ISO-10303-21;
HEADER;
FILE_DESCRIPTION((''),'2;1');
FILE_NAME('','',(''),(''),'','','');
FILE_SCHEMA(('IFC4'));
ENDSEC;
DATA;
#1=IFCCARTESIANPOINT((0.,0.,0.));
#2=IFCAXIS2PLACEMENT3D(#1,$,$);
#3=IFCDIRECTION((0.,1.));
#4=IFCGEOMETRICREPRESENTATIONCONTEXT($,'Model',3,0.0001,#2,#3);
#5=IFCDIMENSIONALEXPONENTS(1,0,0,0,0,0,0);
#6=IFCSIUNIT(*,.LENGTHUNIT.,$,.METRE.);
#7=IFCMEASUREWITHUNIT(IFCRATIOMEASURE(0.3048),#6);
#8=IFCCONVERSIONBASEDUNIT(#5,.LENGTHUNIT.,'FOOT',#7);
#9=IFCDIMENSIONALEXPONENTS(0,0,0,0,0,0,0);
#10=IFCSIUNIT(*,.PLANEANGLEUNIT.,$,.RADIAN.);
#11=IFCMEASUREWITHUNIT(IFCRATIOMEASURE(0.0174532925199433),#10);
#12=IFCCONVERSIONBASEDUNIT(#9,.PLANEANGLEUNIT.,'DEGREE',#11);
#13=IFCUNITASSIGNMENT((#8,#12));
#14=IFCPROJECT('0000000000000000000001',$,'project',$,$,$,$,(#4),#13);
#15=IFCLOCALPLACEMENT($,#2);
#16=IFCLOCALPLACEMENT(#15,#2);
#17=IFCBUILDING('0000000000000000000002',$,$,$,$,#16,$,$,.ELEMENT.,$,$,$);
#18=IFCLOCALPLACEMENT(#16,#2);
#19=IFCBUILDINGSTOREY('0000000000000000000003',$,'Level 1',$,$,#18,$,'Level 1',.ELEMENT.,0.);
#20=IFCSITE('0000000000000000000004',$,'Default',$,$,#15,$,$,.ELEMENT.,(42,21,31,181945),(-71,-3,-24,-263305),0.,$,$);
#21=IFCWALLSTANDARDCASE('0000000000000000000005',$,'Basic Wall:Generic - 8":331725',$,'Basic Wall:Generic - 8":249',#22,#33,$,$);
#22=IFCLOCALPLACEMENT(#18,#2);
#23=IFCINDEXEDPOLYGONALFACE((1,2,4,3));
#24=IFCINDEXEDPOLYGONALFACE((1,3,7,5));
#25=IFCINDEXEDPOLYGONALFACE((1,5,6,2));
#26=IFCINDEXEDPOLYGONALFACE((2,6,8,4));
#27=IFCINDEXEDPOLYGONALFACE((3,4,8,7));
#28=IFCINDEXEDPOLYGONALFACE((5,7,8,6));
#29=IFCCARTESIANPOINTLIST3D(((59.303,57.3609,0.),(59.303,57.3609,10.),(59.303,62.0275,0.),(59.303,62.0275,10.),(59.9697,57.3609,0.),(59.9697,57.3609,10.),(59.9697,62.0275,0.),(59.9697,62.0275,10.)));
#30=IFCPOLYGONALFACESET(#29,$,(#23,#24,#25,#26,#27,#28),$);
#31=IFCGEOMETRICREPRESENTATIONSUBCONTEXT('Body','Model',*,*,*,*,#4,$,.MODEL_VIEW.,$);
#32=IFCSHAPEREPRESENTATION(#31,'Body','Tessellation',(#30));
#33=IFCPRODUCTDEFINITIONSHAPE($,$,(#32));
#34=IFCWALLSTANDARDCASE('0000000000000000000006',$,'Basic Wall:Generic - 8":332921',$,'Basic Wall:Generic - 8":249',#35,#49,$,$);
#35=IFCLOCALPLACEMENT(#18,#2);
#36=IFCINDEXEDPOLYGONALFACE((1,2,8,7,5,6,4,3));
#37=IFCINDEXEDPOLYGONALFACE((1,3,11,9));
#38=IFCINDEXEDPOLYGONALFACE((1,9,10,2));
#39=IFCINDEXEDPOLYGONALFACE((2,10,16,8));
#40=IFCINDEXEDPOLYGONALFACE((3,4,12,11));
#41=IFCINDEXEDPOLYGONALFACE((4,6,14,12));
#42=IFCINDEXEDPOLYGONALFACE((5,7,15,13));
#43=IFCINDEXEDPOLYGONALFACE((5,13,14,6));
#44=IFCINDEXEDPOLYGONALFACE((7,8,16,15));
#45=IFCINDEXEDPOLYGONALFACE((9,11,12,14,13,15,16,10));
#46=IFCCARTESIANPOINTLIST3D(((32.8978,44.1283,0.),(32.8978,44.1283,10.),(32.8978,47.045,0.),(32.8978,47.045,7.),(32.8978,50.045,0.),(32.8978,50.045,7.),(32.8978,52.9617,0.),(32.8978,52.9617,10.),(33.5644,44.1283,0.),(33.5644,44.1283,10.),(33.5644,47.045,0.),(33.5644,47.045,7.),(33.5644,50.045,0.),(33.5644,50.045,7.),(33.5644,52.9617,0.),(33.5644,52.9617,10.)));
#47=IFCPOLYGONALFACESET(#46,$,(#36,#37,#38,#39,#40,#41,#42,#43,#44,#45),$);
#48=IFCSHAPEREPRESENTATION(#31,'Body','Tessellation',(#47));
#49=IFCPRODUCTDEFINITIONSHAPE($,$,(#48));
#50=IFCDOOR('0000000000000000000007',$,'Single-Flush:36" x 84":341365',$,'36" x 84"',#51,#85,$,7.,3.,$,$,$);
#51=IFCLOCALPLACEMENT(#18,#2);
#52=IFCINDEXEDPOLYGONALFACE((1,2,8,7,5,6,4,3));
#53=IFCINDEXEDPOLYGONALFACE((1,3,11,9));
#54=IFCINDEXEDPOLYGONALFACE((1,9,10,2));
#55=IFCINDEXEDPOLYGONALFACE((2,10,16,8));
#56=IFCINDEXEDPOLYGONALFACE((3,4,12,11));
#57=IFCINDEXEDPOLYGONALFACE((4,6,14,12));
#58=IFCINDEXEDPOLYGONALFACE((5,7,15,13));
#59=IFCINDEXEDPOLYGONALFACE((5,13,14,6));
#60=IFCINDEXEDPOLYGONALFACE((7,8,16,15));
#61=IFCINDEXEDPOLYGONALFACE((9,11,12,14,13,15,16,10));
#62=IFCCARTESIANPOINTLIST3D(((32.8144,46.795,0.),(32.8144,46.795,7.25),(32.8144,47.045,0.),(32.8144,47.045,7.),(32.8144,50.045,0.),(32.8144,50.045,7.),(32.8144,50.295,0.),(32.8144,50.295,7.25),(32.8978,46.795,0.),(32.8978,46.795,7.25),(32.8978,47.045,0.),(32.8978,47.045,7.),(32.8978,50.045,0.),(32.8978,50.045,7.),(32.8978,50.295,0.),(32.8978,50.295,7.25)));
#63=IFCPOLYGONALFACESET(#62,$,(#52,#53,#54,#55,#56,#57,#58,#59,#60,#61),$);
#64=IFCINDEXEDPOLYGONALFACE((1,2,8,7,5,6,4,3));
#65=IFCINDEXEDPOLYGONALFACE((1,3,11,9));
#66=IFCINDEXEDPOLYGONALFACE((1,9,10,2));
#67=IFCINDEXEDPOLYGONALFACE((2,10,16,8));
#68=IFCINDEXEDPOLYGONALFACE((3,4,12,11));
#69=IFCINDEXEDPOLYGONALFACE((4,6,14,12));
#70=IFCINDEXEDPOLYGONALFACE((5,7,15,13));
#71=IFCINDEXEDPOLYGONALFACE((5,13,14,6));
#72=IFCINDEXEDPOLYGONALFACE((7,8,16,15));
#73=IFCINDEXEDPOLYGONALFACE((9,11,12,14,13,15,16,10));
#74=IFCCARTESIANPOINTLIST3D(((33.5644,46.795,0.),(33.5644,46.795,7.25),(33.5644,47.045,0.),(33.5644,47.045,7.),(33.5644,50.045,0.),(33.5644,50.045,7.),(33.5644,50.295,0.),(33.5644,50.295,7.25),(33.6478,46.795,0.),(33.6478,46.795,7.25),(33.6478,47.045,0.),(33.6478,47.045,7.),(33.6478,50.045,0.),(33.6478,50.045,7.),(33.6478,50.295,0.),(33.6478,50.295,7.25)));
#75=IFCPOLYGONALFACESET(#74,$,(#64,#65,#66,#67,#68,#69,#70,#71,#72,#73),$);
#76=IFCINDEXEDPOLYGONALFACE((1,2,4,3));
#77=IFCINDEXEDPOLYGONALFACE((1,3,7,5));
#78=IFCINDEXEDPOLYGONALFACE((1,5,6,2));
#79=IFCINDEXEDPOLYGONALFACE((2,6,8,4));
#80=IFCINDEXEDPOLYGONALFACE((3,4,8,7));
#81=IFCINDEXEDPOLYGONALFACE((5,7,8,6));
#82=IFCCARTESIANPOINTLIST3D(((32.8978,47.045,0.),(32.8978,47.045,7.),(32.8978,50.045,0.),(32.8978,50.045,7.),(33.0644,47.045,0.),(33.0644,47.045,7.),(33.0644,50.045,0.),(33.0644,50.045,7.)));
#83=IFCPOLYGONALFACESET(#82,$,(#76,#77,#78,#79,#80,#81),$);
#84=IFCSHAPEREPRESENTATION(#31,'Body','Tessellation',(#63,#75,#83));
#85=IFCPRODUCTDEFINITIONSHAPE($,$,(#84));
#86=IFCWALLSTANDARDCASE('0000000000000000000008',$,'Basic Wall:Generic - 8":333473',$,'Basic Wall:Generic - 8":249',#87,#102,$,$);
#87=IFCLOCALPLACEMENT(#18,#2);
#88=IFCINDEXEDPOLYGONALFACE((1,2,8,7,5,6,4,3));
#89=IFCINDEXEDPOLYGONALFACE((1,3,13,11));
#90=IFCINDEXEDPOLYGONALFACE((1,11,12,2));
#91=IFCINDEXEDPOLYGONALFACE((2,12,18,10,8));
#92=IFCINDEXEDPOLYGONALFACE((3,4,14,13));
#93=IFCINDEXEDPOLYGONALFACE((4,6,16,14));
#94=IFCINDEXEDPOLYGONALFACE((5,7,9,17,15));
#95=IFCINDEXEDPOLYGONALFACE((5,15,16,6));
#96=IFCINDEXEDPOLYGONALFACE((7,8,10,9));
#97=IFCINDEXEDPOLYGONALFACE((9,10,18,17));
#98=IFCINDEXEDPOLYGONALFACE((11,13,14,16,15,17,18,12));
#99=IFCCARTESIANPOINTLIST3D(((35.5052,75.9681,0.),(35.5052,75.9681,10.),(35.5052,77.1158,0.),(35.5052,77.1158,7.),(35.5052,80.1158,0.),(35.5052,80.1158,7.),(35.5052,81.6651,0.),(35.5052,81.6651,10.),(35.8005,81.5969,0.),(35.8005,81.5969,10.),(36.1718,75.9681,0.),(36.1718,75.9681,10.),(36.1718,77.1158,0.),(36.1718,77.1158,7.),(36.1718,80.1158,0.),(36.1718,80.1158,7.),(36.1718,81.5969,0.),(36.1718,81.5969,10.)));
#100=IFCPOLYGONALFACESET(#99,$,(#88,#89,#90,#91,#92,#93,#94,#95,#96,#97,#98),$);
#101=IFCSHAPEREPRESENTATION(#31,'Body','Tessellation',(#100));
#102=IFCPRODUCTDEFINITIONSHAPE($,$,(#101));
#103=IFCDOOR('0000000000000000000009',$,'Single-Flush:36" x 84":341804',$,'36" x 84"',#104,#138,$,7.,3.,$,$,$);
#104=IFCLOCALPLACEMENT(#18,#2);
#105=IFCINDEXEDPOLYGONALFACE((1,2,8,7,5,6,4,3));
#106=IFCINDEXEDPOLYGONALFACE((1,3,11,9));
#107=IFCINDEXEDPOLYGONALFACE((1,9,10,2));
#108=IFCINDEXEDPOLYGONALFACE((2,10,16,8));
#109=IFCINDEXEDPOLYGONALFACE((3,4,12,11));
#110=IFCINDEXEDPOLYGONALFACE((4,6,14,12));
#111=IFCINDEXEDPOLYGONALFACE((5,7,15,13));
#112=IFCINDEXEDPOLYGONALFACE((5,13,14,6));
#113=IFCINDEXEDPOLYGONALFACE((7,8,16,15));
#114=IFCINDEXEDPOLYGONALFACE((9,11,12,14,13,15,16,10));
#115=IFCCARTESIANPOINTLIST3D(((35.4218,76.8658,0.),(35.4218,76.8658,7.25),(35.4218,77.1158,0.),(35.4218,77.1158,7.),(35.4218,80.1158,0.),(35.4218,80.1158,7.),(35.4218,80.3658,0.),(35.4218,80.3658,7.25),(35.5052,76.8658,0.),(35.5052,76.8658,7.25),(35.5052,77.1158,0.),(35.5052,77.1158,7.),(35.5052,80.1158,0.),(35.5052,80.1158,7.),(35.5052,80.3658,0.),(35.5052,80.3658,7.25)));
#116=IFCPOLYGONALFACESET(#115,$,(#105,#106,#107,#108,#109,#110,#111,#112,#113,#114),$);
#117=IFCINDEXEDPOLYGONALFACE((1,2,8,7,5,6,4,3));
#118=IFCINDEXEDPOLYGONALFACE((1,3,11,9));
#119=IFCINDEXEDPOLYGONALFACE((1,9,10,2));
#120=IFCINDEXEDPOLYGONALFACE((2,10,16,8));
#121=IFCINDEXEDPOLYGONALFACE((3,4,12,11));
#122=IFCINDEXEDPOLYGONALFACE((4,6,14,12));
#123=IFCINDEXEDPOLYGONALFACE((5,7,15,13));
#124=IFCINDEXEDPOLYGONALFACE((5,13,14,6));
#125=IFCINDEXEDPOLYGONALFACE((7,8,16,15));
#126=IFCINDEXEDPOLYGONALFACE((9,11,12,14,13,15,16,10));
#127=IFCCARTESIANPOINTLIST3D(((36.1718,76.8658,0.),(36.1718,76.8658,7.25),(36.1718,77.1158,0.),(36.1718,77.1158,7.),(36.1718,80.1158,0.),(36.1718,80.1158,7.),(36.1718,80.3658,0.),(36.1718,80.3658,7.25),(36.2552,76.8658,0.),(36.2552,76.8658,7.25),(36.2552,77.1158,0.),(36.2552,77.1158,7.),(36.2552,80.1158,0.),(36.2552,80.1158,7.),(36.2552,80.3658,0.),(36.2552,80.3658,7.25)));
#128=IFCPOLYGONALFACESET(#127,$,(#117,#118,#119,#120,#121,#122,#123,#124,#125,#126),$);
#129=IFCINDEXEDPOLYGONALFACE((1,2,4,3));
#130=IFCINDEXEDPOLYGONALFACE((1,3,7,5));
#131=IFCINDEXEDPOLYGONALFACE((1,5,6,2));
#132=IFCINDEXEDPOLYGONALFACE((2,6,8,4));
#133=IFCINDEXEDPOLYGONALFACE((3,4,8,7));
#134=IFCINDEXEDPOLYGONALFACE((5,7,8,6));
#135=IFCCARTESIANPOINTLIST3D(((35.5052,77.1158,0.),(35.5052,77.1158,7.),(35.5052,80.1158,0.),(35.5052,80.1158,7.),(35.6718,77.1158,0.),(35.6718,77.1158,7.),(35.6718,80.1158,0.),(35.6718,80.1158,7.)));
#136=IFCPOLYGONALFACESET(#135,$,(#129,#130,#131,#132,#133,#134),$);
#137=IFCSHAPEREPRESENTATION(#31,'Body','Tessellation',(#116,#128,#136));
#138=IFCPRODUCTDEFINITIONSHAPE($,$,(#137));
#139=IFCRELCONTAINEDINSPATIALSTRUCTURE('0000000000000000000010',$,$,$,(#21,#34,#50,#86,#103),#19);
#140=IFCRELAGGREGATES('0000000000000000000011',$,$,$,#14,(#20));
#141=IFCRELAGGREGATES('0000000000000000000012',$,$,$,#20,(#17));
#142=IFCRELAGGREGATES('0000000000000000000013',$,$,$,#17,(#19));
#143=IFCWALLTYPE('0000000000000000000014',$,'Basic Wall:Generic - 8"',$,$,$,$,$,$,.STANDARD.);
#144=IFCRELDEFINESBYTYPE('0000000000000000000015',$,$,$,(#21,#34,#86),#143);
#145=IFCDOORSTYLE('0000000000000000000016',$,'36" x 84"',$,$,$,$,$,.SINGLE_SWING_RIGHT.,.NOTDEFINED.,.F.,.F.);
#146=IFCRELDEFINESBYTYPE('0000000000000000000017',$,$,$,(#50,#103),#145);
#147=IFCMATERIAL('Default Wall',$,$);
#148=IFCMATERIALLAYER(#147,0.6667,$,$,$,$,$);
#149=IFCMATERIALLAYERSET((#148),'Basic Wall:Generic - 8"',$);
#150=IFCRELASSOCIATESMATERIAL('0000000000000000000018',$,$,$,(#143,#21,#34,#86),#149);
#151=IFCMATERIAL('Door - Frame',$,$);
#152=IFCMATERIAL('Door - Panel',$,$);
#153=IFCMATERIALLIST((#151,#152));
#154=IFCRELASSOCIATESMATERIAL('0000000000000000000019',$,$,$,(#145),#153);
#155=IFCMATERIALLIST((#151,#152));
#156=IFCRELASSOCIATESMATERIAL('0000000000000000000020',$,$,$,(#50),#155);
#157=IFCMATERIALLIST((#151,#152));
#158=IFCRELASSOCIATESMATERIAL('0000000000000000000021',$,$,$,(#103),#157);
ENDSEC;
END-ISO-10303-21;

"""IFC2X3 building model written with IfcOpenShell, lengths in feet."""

from ifc_helpers import new_model, entity, si_unit, converted_unit, direction, frame, frame_2d, origin, place, context, subcontext, project, spatial, polyline, rectangle, outline, extrude, source, transform, mapped, material, material_list, layer, layer_set, layer_usage, type_object, type_shapes, element, fill, save


model = new_model("IFC2X3")

# Units and contexts
model_context = context("Model", 3, precision=0.0001, world=origin(), true_north=direction((0.0, 1.0)))
body_context = subcontext(model_context, "Body", "Model", "MODEL_VIEW")
ifc_project = project(units=[converted_unit("LENGTHUNIT", "FOOT", entity("IfcRatioMeasure", 0.3048), si_unit("LENGTHUNIT", "METRE"), dimensions=[1, 0, 0, 0, 0, 0, 0]), converted_unit("PLANEANGLEUNIT", "DEGREE", entity("IfcRatioMeasure", 0.0174532925199433), si_unit("PLANEANGLEUNIT", "RADIAN"), dimensions=[0, 0, 0, 0, 0, 0, 0])], contexts=[model_context])

# Site, building, storey
site_placement = place(None, origin())
site = spatial("IfcSite", under=ifc_project, at=site_placement, Name="Default", CompositionType="ELEMENT", RefLatitude=(42, 21, 31, 181945), RefLongitude=(-71, -3, -24, -263305), RefElevation=0.0)
building_placement = place(site_placement, origin())
building = spatial("IfcBuilding", under=site, at=building_placement, CompositionType="ELEMENT")
storey_placement = place(building_placement, origin())
storey = spatial("IfcBuildingStorey", under=building, at=storey_placement, Name="Level 1", LongName="Level 1", CompositionType="ELEMENT", Elevation=0.0)

# Shared definitions
ifc_material_1 = material(Name="Default Wall")
ifc_layer = layer(ifc_material_1, 0.6667)
ifc_layer_set = layer_set([ifc_layer], Name="Basic Wall:Generic - 8\"")
wall_type = type_object("IfcWallType", Name="Basic Wall:Generic - 8\"", PredefinedType="STANDARD", material=ifc_layer_set)

# Shared definitions
ifc_material_2 = material(Name="Door - Frame")
ifc_material_3 = material(Name="Door - Panel")
ifc_material_list_1 = material_list([ifc_material_2, ifc_material_3])
door_style = type_object("IfcDoorStyle", Name="36\" x 84\"", ConstructionType="NOTDEFINED", OperationType="SINGLE_SWING_RIGHT", ParameterTakesPrecedence=False, Sizeable=False, material=ifc_material_list_1)
shared_shape = source(origin(), body_context, "Body", "SweptSolid", [
    extrude(outline(polyline([(-1.75, -3.6875), (1.75, -3.6875), (1.75, 3.5625), (1.5, 3.5625), (1.5, -3.4375), (-1.5, -3.4375), (-1.5, 3.5625), (-1.75, 3.5625), (-1.75, -3.6875)])), frame((1.5, 0.6667, 3.5625), z_axis=(0.0, 1.0, 0.0), x_axis=(1.0, 0.0, 0.0)), (0.0, 0.0, 1.0), 0.0833),
    extrude(outline(polyline([(-3.6875, -1.75), (3.5625, -1.75), (3.5625, -1.5), (-3.4375, -1.5), (-3.4375, 1.5), (3.5625, 1.5), (3.5625, 1.75), (-3.6875, 1.75), (-3.6875, -1.75)])), frame((1.5, -0.0833, 3.5625), z_axis=(0.0, 1.0, 0.0), x_axis=(0.0, 0.0, -1.0)), (0.0, 0.0, 1.0), 0.0833),
    extrude(rectangle(XDim=0.1667, YDim=3.0, at=frame_2d((0.0, 0.0), x_axis=(1.0, 0.0))), frame((1.5, 0.5833, 0.0), z_axis=(0.0, 0.0, 1.0), x_axis=(0.0, 1.0, 0.0)), (0.0, 0.0, 1.0), 7.0),
])
type_shapes(door_style, [shared_shape])

# Wall
ifc_layer_usage_1 = layer_usage(ifc_layer_set, "AXIS2", "NEGATIVE", 0.3333)
wall_1_placement = place(storey_placement, frame((59.6363, 62.0275, 0.0), z_axis=(0.0, 0.0, 1.0), x_axis=(0.0, -1.0, 0.0)))
element("IfcWallStandardCase", 1, at=wall_1_placement, inside=storey, type_object=wall_type, material=ifc_layer_usage_1, Name="Basic Wall:Generic - 8\":331725", ObjectType="Basic Wall:Generic - 8\":249", context=body_context, shape_type="SweptSolid", body=[
    extrude(rectangle(XDim=4.6667, YDim=0.6667, at=frame_2d((2.3333, 0.0), x_axis=(-1.0, 0.0))), origin(), (0.0, 0.0, 1.0), 10.0),
])

# Walls, openings, doors
ifc_layer_usage_2 = layer_usage(ifc_layer_set, "AXIS2", "NEGATIVE", 0.3333)
wall_2_placement = place(storey_placement, frame((33.2311, 52.9617, 0.0), z_axis=(0.0, 0.0, 1.0), x_axis=(0.0, -1.0, 0.0)))
wall_2 = element("IfcWallStandardCase", 2, at=wall_2_placement, inside=storey, type_object=wall_type, material=ifc_layer_usage_2, Name="Basic Wall:Generic - 8\":332921", ObjectType="Basic Wall:Generic - 8\":249", context=body_context, shape_type="SweptSolid", body=[
    extrude(rectangle(XDim=8.8333, YDim=0.6667, at=frame_2d((4.4167, 0.0), x_axis=(-1.0, 0.0))), origin(), (0.0, 0.0, 1.0), 10.0),
])
opening_1_placement = place(wall_2_placement, frame((5.9167, 0.3333, 0.0)))
opening_1 = element("IfcOpeningElement", 3, at=opening_1_placement, cuts=wall_2, ObjectType="Opening", context=body_context, shape_type="SweptSolid", body=[
    extrude(rectangle(XDim=3.0, YDim=7.0, at=frame_2d((3.5, 1.5), x_axis=(0.0, 1.0))), frame((0.0, 0.0, 0.0), z_axis=(0.0, -1.0, 0.0), x_axis=(0.0, 0.0, 1.0)), (0.0, 0.0, 1.0), 0.6667),
])
ifc_material_list_2 = material_list([ifc_material_2, ifc_material_3])
door_1_placement = place(opening_1_placement, frame((0.0, 0.0, 0.0), z_axis=(0.0, 0.0, 1.0), x_axis=(-1.0, 0.0, 0.0)))
door_1 = element("IfcDoor", 4, at=door_1_placement, inside=storey, type_object=door_style, material=ifc_material_list_2, Name="Single-Flush:36\" x 84\":341365", ObjectType="36\" x 84\"", OverallHeight=7.0, OverallWidth=3.0, context=body_context, shape_type="MappedRepresentation", body=[
    mapped(shared_shape, transform((0.0, 0.0, 0.0), scale=1.0)),
])
fill(opening_1, door_1)
ifc_layer_usage_3 = layer_usage(ifc_layer_set, "AXIS2", "NEGATIVE", 0.3333)
wall_3_placement = place(storey_placement, frame((35.8385, 81.6651, 0.0), z_axis=(0.0, 0.0, 1.0), x_axis=(0.0, -1.0, 0.0)))
wall_3 = element("IfcWallStandardCase", 5, at=wall_3_placement, inside=storey, type_object=wall_type, material=ifc_layer_usage_3, Name="Basic Wall:Generic - 8\":333473", ObjectType="Basic Wall:Generic - 8\":249", context=body_context, shape_type="SweptSolid", body=[
    extrude(outline(polyline([(0.0, -0.3333), (5.697, -0.3333), (5.697, 0.3333), (0.0682, 0.3333), (0.0682, -0.038), (0.0, -0.3333)])), origin(), (0.0, 0.0, 1.0), 10.0),
])
opening_2_placement = place(wall_3_placement, frame((4.5493, 0.3333, 0.0)))
opening_2 = element("IfcOpeningElement", 6, at=opening_2_placement, cuts=wall_3, ObjectType="Opening", context=body_context, shape_type="SweptSolid", body=[
    extrude(rectangle(XDim=3.0, YDim=7.0, at=frame_2d((3.5, 1.5), x_axis=(0.0, 1.0))), frame((0.0, 0.0, 0.0), z_axis=(0.0, -1.0, 0.0), x_axis=(0.0, 0.0, 1.0)), (0.0, 0.0, 1.0), 0.6667),
])
ifc_material_list_3 = material_list([ifc_material_2, ifc_material_3])
door_2_placement = place(opening_2_placement, frame((0.0, 0.0, 0.0), z_axis=(0.0, 0.0, 1.0), x_axis=(-1.0, 0.0, 0.0)))
door_2 = element("IfcDoor", 7, at=door_2_placement, inside=storey, type_object=door_style, material=ifc_material_list_3, Name="Single-Flush:36\" x 84\":341804", ObjectType="36\" x 84\"", OverallHeight=7.0, OverallWidth=3.0, context=body_context, shape_type="MappedRepresentation", body=[
    mapped(shared_shape, transform((0.0, 0.0, 0.0), scale=1.0)),
])
fill(opening_2, door_2)

save(model, "model.ifc")
